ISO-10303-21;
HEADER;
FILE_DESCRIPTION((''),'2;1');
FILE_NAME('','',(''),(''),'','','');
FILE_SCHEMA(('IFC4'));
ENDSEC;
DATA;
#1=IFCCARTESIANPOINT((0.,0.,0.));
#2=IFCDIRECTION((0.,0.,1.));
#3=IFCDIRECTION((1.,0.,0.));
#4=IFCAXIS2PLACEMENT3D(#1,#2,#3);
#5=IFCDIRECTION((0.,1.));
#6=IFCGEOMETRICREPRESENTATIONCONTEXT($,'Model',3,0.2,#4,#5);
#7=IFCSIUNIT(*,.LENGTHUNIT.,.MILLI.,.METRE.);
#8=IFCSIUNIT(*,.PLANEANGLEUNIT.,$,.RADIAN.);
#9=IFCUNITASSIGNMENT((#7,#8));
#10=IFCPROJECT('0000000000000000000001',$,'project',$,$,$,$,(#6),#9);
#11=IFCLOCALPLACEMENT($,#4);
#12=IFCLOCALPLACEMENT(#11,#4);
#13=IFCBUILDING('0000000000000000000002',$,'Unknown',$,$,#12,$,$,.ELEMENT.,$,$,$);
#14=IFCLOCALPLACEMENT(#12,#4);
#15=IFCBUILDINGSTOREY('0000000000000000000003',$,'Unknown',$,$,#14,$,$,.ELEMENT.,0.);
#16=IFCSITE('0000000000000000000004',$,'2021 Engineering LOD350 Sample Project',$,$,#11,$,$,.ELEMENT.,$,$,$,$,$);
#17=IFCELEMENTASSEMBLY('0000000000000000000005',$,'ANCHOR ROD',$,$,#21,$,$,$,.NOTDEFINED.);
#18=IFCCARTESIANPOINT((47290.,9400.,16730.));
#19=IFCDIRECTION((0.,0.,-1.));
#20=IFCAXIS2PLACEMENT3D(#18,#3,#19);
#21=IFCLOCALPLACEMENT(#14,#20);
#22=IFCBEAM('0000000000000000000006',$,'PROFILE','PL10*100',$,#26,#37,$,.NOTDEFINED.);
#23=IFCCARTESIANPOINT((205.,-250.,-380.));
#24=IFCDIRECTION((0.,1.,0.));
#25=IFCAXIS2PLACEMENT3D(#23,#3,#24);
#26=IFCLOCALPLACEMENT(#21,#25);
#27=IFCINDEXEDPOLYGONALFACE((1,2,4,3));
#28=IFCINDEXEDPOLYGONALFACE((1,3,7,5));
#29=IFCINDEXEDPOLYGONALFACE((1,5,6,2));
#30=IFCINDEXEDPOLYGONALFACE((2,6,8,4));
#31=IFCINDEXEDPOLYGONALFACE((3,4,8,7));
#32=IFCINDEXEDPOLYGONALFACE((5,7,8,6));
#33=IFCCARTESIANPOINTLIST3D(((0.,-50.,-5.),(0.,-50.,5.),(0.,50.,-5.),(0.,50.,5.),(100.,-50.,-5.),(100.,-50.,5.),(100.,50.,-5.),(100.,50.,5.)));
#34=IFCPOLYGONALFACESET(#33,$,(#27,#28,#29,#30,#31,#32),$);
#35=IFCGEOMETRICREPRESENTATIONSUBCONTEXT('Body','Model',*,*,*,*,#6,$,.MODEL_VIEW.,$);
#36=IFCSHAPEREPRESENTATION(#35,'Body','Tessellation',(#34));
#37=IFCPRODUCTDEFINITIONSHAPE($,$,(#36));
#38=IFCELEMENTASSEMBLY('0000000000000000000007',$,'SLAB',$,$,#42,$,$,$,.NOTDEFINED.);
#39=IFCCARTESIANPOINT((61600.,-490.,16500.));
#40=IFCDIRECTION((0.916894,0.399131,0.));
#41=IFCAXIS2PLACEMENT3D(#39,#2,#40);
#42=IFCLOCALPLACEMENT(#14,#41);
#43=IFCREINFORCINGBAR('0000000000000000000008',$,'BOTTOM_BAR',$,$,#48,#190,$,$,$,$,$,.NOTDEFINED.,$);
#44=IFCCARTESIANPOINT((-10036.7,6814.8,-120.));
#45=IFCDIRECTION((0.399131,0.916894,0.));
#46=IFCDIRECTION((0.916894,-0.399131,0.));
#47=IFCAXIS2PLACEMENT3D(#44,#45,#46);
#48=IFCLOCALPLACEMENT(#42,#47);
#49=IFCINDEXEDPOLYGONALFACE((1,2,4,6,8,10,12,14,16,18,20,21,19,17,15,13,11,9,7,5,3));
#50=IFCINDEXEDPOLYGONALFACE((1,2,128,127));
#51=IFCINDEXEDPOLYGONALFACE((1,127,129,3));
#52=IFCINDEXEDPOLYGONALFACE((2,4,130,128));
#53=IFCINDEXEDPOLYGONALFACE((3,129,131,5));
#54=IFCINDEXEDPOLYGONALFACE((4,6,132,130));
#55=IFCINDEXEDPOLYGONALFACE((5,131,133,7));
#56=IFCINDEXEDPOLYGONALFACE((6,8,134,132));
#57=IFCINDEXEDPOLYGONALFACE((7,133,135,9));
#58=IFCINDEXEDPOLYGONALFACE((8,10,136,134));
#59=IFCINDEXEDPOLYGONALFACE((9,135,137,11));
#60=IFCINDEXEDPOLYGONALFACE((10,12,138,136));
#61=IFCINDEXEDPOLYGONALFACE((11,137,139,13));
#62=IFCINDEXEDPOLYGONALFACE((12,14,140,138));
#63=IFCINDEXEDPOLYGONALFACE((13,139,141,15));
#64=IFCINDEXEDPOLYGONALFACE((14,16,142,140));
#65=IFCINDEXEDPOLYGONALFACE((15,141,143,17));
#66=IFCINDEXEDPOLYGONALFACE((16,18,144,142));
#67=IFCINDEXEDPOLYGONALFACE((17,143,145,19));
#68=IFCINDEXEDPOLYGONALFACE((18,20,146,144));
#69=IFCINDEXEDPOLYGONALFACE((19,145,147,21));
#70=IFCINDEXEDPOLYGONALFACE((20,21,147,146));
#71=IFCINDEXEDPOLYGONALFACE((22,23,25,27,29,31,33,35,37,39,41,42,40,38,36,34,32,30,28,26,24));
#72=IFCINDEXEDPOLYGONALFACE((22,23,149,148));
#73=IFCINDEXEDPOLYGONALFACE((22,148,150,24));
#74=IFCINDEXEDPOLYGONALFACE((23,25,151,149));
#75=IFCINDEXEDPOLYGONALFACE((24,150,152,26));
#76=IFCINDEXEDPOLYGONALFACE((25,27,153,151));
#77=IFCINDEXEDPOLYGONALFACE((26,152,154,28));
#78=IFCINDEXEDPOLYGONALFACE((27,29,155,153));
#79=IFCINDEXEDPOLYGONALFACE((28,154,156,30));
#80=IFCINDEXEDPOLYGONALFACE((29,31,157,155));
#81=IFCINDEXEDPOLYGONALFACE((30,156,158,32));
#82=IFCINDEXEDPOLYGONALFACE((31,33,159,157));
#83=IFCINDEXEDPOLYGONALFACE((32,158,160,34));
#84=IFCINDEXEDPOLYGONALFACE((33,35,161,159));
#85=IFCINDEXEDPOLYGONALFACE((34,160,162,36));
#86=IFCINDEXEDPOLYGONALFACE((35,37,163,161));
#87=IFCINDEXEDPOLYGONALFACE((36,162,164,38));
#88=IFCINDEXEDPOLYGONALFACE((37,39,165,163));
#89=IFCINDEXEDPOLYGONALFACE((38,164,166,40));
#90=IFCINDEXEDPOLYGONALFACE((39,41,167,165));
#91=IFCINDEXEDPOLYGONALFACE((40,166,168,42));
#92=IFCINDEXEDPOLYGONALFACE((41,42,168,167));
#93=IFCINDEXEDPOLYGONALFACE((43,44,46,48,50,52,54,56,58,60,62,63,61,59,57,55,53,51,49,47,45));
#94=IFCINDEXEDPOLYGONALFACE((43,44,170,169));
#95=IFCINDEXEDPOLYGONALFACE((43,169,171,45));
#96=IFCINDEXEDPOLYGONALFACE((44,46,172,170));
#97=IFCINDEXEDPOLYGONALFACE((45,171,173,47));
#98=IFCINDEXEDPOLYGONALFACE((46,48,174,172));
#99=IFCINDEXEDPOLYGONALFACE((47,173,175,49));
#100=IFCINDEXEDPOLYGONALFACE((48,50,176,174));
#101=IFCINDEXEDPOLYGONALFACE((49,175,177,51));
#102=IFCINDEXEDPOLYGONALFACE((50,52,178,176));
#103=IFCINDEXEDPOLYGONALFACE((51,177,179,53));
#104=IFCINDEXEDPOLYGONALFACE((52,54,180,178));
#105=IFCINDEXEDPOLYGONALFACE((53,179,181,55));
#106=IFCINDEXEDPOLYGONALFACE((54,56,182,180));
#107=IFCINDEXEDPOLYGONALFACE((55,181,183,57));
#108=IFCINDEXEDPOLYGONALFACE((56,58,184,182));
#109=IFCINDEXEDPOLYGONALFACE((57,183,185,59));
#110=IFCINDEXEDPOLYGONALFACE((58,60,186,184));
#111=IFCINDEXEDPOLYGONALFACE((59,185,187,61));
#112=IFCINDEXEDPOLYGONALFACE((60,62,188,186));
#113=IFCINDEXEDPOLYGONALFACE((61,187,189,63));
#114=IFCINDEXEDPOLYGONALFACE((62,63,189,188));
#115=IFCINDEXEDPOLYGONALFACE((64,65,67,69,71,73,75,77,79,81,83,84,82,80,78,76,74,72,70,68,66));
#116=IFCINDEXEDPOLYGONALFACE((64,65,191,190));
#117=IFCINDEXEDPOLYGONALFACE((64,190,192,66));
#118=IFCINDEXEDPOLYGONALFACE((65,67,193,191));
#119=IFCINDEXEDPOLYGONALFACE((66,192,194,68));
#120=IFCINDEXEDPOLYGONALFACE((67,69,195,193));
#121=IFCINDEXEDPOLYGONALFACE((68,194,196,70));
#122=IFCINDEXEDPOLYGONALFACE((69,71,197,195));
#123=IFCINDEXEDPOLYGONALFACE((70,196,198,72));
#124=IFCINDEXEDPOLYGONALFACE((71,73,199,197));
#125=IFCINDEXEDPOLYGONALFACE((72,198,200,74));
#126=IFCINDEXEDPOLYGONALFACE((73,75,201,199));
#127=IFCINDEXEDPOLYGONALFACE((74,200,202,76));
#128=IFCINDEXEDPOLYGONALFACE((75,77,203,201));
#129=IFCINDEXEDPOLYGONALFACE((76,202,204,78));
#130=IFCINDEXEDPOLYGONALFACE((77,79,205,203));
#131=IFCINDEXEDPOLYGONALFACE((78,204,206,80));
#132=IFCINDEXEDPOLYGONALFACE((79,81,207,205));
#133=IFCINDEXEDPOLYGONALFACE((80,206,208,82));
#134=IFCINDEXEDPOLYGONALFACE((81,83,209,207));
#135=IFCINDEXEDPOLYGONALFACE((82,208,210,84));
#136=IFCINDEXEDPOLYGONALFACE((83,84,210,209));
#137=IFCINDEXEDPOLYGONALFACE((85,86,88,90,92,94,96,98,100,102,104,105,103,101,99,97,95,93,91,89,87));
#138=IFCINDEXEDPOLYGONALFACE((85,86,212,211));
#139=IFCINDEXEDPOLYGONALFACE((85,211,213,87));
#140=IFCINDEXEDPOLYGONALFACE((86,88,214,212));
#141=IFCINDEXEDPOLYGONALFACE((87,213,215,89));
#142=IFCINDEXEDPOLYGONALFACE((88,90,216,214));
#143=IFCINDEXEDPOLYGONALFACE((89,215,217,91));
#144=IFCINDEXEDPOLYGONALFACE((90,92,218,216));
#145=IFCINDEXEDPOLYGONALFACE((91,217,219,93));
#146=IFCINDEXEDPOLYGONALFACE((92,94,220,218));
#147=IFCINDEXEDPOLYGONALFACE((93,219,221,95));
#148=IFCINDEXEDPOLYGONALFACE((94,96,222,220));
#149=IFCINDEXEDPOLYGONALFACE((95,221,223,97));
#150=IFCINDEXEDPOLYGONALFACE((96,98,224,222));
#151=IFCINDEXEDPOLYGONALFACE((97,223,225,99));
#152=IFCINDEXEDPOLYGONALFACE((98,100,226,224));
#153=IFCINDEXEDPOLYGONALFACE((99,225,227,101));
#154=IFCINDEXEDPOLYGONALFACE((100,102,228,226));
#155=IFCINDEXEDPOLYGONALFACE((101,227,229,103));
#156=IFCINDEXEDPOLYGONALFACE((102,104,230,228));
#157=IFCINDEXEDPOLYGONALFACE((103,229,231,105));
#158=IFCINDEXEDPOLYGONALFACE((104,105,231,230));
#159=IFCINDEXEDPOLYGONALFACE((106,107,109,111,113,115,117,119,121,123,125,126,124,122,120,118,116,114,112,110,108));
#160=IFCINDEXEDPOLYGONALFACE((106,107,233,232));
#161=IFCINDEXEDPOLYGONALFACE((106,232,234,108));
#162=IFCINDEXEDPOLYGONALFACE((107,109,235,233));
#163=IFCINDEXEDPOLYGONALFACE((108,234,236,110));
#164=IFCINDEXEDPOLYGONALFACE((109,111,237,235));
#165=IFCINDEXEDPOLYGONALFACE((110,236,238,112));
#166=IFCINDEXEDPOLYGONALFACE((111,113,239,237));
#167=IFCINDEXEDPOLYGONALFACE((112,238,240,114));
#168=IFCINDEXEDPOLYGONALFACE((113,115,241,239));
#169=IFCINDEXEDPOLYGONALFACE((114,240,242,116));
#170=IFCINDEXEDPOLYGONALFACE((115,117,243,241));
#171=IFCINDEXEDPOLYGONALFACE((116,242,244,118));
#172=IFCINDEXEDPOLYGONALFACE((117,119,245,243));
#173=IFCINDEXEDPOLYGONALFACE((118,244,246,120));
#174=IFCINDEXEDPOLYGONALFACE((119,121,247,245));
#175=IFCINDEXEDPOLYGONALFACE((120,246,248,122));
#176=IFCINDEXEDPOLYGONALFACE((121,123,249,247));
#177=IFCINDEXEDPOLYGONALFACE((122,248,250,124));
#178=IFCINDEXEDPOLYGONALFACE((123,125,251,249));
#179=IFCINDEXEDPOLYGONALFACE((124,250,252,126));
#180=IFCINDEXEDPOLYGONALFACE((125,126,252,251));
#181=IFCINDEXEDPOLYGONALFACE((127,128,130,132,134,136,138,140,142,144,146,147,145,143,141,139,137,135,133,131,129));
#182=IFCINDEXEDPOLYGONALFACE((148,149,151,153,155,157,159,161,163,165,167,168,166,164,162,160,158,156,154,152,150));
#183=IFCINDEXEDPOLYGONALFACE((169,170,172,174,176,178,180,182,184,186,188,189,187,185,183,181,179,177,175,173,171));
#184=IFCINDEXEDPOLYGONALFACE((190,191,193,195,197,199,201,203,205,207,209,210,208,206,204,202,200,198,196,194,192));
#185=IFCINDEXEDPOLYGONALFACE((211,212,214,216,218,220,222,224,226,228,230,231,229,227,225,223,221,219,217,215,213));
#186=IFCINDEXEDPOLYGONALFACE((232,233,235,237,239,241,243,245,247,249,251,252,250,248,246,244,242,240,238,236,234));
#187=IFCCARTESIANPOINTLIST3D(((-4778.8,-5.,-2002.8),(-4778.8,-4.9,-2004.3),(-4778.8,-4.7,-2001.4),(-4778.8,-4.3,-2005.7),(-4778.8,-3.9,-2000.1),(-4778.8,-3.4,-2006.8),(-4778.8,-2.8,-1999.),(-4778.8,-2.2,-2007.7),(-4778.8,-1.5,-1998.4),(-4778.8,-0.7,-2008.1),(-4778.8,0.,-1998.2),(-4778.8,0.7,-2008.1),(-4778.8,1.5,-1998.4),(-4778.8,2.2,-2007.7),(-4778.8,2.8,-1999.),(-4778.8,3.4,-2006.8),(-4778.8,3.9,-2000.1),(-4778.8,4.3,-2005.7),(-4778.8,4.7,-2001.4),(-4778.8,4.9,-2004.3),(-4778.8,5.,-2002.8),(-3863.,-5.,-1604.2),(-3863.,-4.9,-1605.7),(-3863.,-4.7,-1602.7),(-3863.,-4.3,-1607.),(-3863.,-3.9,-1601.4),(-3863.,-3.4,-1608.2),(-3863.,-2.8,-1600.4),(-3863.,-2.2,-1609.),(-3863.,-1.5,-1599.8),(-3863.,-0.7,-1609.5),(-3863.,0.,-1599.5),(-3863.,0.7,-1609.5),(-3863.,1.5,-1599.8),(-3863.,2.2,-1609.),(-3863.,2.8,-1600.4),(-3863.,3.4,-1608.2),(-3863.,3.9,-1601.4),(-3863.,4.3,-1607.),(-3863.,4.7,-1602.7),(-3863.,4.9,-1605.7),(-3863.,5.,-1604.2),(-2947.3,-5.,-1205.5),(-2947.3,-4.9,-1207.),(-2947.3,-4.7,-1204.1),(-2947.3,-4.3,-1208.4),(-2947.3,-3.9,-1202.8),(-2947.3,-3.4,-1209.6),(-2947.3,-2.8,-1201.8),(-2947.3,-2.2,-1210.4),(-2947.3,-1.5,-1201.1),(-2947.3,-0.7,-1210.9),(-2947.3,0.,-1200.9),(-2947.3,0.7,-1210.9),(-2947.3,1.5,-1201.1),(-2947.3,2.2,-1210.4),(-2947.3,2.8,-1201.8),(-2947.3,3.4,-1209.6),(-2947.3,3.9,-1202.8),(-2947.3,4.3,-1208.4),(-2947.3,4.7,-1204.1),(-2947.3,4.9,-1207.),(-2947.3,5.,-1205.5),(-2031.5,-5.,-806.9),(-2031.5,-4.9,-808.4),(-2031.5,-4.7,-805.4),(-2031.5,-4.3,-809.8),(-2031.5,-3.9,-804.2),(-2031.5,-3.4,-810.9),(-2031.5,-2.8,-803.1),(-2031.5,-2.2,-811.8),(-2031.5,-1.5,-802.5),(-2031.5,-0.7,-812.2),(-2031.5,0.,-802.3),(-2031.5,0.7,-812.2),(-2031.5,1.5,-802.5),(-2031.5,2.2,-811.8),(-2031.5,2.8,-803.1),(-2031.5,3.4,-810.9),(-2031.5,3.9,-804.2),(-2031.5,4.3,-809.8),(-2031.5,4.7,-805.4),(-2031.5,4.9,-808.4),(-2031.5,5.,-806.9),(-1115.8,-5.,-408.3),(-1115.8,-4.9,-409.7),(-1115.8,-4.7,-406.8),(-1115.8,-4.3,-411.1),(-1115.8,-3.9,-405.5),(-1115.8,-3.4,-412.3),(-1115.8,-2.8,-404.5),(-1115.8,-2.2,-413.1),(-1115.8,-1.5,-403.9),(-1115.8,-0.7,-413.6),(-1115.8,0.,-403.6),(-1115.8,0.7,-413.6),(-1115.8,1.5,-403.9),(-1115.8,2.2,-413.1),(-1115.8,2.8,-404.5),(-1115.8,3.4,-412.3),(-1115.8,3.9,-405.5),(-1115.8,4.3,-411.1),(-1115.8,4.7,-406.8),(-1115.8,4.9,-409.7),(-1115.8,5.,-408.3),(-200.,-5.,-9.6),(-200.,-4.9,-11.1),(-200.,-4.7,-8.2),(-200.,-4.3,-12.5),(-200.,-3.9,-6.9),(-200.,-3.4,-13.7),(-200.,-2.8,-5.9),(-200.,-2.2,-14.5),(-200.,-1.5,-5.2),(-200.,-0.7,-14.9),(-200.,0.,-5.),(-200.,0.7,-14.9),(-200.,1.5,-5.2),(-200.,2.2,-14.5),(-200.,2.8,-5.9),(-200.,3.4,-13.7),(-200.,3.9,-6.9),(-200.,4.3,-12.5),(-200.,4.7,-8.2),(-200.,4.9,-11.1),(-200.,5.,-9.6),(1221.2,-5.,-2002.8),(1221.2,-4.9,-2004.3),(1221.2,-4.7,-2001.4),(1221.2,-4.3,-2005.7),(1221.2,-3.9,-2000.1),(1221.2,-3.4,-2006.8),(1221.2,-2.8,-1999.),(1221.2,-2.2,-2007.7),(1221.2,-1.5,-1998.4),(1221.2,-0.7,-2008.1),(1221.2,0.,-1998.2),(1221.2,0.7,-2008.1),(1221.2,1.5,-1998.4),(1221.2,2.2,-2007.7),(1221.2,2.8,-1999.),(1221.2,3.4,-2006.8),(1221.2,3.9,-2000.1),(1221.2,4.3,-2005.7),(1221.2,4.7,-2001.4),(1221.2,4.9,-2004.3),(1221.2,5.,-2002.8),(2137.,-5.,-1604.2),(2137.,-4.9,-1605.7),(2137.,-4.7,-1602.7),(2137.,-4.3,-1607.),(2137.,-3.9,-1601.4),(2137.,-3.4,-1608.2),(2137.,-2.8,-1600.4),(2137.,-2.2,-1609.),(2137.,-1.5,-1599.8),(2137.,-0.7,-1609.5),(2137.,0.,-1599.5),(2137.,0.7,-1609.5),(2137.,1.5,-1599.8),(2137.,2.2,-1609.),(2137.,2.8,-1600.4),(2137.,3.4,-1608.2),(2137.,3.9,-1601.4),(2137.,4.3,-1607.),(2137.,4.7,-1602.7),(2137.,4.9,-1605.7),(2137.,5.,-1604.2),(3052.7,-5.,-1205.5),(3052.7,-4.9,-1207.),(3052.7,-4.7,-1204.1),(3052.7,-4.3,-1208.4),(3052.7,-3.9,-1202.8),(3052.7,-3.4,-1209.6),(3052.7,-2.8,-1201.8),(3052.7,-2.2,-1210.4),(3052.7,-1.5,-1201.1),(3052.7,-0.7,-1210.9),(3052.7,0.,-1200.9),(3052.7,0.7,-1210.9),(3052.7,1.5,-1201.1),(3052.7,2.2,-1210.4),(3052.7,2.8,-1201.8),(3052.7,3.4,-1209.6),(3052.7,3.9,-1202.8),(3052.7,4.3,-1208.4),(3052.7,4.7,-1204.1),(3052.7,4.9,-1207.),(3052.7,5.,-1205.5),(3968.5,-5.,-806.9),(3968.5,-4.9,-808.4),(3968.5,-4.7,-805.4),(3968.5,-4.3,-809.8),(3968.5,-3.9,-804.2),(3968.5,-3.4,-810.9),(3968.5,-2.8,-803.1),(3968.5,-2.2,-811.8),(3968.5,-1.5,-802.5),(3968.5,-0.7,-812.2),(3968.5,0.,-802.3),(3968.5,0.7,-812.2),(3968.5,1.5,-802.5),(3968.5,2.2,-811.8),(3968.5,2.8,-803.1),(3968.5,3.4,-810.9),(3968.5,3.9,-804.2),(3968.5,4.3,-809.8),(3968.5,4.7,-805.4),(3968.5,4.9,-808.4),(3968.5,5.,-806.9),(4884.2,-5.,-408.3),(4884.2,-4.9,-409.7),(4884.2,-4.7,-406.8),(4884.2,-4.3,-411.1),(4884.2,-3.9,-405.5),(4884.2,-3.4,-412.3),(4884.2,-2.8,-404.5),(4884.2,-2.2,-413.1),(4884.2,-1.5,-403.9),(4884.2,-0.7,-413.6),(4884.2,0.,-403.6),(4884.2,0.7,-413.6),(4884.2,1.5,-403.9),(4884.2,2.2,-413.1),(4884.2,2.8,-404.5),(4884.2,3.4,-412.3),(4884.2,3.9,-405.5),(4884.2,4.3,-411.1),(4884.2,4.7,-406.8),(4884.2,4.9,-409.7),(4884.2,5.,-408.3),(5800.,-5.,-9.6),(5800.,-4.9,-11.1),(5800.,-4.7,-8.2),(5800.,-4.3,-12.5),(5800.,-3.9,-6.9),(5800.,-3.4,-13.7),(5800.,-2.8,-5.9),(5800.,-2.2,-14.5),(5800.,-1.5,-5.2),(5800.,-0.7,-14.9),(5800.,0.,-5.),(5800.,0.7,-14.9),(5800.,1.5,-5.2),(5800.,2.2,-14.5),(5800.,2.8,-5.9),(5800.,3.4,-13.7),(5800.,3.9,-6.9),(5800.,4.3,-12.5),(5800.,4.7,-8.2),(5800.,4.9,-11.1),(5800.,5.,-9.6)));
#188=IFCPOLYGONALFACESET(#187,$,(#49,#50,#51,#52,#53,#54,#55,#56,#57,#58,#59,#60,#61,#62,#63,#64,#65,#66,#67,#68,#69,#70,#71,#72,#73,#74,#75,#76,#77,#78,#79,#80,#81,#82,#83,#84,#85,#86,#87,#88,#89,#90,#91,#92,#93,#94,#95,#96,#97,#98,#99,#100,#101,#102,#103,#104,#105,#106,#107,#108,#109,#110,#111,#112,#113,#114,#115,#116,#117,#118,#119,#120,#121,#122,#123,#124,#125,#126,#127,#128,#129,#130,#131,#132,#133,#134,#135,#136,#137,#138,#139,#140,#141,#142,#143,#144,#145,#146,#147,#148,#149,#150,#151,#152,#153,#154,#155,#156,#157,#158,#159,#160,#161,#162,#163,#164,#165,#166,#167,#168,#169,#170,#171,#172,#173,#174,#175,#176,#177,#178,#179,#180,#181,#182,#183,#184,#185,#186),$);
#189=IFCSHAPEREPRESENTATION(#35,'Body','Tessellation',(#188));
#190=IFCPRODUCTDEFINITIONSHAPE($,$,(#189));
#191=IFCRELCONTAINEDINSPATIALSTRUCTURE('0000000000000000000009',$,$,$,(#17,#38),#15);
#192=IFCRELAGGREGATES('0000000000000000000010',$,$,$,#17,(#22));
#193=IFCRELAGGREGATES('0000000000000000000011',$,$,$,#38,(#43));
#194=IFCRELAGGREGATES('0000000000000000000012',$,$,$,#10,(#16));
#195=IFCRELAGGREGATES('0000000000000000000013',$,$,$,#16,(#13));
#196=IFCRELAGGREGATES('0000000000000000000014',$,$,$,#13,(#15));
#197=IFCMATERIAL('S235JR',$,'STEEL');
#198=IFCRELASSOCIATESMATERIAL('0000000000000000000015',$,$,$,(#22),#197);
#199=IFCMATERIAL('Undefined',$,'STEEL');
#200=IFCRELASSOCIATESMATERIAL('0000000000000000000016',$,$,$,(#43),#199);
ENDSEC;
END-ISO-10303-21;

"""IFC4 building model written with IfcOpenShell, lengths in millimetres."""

from ifc_helpers import new_model, entity, si_unit, direction, frame, origin_with_axes, place, context, subcontext, project, spatial, line, indexed_curve, outline, extrude, source, transform, mapped, material, element, aggregate, save


model = new_model("IFC4")

# Units and contexts
model_context = context("Model", 3, precision=0.2, world=origin_with_axes(), true_north=direction((0.0, 1.0)))
body_context = subcontext(model_context, "Body", "Model", "MODEL_VIEW")
ifc_project = project(units=[si_unit("LENGTHUNIT", "METRE", prefix="MILLI"), si_unit("PLANEANGLEUNIT", "RADIAN")], contexts=[model_context])

# Site, building, storey
site_placement = place(None, origin_with_axes())
site = spatial("IfcSite", under=ifc_project, at=site_placement, Name="2021 Engineering LOD350 Sample Project", CompositionType="ELEMENT")
building_placement = place(site_placement, origin_with_axes())
building = spatial("IfcBuilding", under=site, at=building_placement, Name="Unknown", CompositionType="ELEMENT")
storey_placement = place(building_placement, origin_with_axes())
storey = spatial("IfcBuildingStorey", under=building, at=storey_placement, Name="Unknown", CompositionType="ELEMENT", Elevation=0.0)

# Element assembly, beam
assembly_1_placement = place(storey_placement, frame((47290.0, 9400.0, 16730.0), z_axis=(1.0, 0.0, 0.0), x_axis=(0.0, 0.0, -1.0)))
assembly_1 = element("IfcElementAssembly", 1, at=assembly_1_placement, inside=storey, Name="ANCHOR ROD", PredefinedType="NOTDEFINED")
ifc_material_1 = material(Name="S235JR", Category="STEEL")
beam_placement = place(assembly_1_placement, frame((205.0, -250.0, -380.0), z_axis=(1.0, 0.0, 0.0), x_axis=(0.0, 1.0, 0.0)))
beam = element("IfcBeam", 2, at=beam_placement, material=ifc_material_1, Name="PROFILE", Description="PL10*100", PredefinedType="NOTDEFINED", context=body_context, shape_type="SolidModel", body=[
    extrude(outline(indexed_curve([(-5.0, -50.0), (5.0, -50.0), (5.0, 50.0), (-5.0, 50.0)], segments=[line(1, 2, 3, 4, 1)])), frame((0.0, 0.0, 0.0), z_axis=(-1.0, 0.0, 0.0), x_axis=(0.0, 0.0, 1.0)), (0.0, 0.0, -1.0), 100.0),
])

# Element assembly, reinforcing bar
assembly_2_placement = place(storey_placement, frame((61600.0, -490.0, 16500.0), z_axis=(0.0, 0.0, 1.0), x_axis=(0.916894, 0.399131, 0.0)))
assembly_2 = element("IfcElementAssembly", 3, at=assembly_2_placement, inside=storey, Name="SLAB", PredefinedType="NOTDEFINED")
ifc_material_2 = material(Name="Undefined", Category="STEEL")
shared_shape_1 = source(origin_with_axes(), body_context, "Body", "AdvancedSweptSolid", [
    entity("IfcSweptDiskSolid", entity("IfcIndexedPolyCurve", entity("IfcCartesianPointList3D", [[-200.0, 0.0, -10.0], [5800.0, 0.0, -10.0]]), [entity("IfcLineIndex", [1, 2])]), 5.0),
])
reinforcing_bar_1_placement = place(assembly_2_placement, frame((-10036.7, 6814.8, -120.0), z_axis=(0.399131, 0.916894, 0.0), x_axis=(0.916894, -0.399131, 0.0)))
reinforcing_bar_1 = element("IfcReinforcingBar", 4, at=reinforcing_bar_1_placement, material=ifc_material_2, Name="BOTTOM_BAR", PredefinedType="NOTDEFINED", context=body_context, shape_type="MappedRepresentation", body=[
    mapped(shared_shape_1, transform((0.0, 0.0, 0.0))),
    mapped(shared_shape_1, transform((-915.8, 0.0, -398.6))),
    mapped(shared_shape_1, transform((-1831.5, 0.0, -797.3))),
    mapped(shared_shape_1, transform((-2747.3, 0.0, -1195.9))),
    mapped(shared_shape_1, transform((-3663.0, 0.0, -1594.5))),
    mapped(shared_shape_1, transform((-4578.8, 0.0, -1993.2))),
])

aggregate(assembly_1, [beam])

aggregate(assembly_2, [reinforcing_bar_1])

save(model, "model.ifc")
